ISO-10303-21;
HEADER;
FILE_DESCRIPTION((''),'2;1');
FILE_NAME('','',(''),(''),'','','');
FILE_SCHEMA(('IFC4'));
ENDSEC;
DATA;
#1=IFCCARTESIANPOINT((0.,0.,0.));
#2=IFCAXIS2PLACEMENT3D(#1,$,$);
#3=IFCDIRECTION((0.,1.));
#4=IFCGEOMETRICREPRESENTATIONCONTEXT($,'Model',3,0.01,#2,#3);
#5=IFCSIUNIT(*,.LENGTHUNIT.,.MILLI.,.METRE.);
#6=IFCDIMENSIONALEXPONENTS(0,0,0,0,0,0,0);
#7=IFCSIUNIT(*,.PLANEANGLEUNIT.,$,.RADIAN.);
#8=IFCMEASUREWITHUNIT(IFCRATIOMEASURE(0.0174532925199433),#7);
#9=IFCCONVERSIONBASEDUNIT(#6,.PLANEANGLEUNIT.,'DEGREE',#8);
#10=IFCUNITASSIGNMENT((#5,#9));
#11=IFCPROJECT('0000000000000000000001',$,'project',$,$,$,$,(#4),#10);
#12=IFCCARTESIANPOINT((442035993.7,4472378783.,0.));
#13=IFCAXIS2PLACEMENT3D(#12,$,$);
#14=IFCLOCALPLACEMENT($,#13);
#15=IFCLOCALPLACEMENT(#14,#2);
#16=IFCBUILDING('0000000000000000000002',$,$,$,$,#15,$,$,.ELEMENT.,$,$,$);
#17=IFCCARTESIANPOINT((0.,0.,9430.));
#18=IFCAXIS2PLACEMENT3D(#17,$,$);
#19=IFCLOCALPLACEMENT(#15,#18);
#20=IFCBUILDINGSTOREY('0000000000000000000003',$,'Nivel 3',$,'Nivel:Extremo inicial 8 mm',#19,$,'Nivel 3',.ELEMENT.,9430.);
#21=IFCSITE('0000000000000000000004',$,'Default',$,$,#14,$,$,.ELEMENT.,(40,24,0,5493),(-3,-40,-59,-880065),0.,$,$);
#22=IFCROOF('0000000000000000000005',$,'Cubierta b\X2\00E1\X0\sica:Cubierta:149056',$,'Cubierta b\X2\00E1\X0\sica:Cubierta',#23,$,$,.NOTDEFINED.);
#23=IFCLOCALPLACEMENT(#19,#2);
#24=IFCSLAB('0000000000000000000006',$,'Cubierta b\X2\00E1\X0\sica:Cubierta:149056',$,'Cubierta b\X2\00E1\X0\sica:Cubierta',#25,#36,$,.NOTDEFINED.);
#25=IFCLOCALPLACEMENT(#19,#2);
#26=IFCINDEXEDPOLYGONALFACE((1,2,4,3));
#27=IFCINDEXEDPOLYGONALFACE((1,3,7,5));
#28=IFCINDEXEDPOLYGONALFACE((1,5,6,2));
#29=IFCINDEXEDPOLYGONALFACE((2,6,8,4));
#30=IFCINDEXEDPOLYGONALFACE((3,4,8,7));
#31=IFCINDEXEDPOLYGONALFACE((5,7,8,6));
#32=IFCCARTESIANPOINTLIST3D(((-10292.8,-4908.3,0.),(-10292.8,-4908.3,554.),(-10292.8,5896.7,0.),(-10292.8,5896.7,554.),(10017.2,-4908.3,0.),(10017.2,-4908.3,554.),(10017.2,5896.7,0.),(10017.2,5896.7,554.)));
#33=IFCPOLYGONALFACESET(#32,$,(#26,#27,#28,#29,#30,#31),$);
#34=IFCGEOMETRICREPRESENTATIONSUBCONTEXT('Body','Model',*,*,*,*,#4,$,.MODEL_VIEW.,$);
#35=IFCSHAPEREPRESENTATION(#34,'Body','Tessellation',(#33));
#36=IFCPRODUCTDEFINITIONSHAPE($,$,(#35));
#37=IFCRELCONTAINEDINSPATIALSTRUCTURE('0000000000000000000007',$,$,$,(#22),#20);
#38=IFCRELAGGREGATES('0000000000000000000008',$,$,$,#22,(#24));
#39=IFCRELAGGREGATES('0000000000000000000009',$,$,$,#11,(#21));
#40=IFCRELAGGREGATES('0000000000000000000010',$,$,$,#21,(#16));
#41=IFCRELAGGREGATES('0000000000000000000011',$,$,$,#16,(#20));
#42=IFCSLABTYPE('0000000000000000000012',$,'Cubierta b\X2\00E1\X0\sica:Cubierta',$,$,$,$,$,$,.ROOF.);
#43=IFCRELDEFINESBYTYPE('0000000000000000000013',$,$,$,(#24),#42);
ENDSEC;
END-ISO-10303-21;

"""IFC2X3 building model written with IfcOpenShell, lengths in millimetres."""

from ifc_helpers import new_model, entity, si_unit, converted_unit, direction, frame, frame_2d, origin, place, context, subcontext, project, spatial, rectangle, extrude, type_object, element, aggregate, save


model = new_model("IFC2X3")

# Units and contexts
model_context = context("Model", 3, precision=0.01, world=origin(), true_north=direction((0.0, 1.0)))
body_context = subcontext(model_context, "Body", "Model", "MODEL_VIEW")
ifc_project = project(units=[si_unit("LENGTHUNIT", "METRE", prefix="MILLI"), converted_unit("PLANEANGLEUNIT", "DEGREE", entity("IfcRatioMeasure", 0.0174532925199433), si_unit("PLANEANGLEUNIT", "RADIAN"), dimensions=[0, 0, 0, 0, 0, 0, 0])], contexts=[model_context])

# Site, building, storey
site_placement = place(None, frame((442035993.7, 4472378783.0, 0.0)))
site = spatial("IfcSite", under=ifc_project, at=site_placement, Name="Default", CompositionType="ELEMENT", RefLatitude=(40, 24, 0, 5493), RefLongitude=(-3, -40, -59, -880065), RefElevation=0.0)
building_placement = place(site_placement, origin())
building = spatial("IfcBuilding", under=site, at=building_placement, CompositionType="ELEMENT")
storey_placement = place(building_placement, frame((0.0, 0.0, 9430.0)))
storey = spatial("IfcBuildingStorey", under=building, at=storey_placement, Name="Nivel 3", ObjectType="Nivel:Extremo inicial 8 mm", LongName="Nivel 3", CompositionType="ELEMENT", Elevation=9430.0)

# Roof, slab
roof_placement = place(storey_placement, frame((-10292.8, -4908.3, 0.0)))
roof = element("IfcRoof", 1, at=roof_placement, inside=storey, Name="Cubierta básica:Cubierta:149056", ObjectType="Cubierta básica:Cubierta", ShapeType="NOTDEFINED")
slab_type = type_object("IfcSlabType", Name="Cubierta básica:Cubierta", PredefinedType="ROOF")
slab_placement = place(roof_placement, origin())
slab = element("IfcSlab", 2, at=slab_placement, type_object=slab_type, Name="Cubierta básica:Cubierta:149056", ObjectType="Cubierta básica:Cubierta", PredefinedType="NOTDEFINED", context=body_context, shape_type="SweptSolid", body=[
    extrude(rectangle(XDim=10805.0, YDim=20310.0, at=frame_2d((0.0, 0.0), x_axis=(0.0, -1.0))), frame((10155.0, 5402.5, 0.0)), (0.0, 0.0, 1.0), 554.0),
])
aggregate(roof, [slab])

save(model, "model.ifc")
